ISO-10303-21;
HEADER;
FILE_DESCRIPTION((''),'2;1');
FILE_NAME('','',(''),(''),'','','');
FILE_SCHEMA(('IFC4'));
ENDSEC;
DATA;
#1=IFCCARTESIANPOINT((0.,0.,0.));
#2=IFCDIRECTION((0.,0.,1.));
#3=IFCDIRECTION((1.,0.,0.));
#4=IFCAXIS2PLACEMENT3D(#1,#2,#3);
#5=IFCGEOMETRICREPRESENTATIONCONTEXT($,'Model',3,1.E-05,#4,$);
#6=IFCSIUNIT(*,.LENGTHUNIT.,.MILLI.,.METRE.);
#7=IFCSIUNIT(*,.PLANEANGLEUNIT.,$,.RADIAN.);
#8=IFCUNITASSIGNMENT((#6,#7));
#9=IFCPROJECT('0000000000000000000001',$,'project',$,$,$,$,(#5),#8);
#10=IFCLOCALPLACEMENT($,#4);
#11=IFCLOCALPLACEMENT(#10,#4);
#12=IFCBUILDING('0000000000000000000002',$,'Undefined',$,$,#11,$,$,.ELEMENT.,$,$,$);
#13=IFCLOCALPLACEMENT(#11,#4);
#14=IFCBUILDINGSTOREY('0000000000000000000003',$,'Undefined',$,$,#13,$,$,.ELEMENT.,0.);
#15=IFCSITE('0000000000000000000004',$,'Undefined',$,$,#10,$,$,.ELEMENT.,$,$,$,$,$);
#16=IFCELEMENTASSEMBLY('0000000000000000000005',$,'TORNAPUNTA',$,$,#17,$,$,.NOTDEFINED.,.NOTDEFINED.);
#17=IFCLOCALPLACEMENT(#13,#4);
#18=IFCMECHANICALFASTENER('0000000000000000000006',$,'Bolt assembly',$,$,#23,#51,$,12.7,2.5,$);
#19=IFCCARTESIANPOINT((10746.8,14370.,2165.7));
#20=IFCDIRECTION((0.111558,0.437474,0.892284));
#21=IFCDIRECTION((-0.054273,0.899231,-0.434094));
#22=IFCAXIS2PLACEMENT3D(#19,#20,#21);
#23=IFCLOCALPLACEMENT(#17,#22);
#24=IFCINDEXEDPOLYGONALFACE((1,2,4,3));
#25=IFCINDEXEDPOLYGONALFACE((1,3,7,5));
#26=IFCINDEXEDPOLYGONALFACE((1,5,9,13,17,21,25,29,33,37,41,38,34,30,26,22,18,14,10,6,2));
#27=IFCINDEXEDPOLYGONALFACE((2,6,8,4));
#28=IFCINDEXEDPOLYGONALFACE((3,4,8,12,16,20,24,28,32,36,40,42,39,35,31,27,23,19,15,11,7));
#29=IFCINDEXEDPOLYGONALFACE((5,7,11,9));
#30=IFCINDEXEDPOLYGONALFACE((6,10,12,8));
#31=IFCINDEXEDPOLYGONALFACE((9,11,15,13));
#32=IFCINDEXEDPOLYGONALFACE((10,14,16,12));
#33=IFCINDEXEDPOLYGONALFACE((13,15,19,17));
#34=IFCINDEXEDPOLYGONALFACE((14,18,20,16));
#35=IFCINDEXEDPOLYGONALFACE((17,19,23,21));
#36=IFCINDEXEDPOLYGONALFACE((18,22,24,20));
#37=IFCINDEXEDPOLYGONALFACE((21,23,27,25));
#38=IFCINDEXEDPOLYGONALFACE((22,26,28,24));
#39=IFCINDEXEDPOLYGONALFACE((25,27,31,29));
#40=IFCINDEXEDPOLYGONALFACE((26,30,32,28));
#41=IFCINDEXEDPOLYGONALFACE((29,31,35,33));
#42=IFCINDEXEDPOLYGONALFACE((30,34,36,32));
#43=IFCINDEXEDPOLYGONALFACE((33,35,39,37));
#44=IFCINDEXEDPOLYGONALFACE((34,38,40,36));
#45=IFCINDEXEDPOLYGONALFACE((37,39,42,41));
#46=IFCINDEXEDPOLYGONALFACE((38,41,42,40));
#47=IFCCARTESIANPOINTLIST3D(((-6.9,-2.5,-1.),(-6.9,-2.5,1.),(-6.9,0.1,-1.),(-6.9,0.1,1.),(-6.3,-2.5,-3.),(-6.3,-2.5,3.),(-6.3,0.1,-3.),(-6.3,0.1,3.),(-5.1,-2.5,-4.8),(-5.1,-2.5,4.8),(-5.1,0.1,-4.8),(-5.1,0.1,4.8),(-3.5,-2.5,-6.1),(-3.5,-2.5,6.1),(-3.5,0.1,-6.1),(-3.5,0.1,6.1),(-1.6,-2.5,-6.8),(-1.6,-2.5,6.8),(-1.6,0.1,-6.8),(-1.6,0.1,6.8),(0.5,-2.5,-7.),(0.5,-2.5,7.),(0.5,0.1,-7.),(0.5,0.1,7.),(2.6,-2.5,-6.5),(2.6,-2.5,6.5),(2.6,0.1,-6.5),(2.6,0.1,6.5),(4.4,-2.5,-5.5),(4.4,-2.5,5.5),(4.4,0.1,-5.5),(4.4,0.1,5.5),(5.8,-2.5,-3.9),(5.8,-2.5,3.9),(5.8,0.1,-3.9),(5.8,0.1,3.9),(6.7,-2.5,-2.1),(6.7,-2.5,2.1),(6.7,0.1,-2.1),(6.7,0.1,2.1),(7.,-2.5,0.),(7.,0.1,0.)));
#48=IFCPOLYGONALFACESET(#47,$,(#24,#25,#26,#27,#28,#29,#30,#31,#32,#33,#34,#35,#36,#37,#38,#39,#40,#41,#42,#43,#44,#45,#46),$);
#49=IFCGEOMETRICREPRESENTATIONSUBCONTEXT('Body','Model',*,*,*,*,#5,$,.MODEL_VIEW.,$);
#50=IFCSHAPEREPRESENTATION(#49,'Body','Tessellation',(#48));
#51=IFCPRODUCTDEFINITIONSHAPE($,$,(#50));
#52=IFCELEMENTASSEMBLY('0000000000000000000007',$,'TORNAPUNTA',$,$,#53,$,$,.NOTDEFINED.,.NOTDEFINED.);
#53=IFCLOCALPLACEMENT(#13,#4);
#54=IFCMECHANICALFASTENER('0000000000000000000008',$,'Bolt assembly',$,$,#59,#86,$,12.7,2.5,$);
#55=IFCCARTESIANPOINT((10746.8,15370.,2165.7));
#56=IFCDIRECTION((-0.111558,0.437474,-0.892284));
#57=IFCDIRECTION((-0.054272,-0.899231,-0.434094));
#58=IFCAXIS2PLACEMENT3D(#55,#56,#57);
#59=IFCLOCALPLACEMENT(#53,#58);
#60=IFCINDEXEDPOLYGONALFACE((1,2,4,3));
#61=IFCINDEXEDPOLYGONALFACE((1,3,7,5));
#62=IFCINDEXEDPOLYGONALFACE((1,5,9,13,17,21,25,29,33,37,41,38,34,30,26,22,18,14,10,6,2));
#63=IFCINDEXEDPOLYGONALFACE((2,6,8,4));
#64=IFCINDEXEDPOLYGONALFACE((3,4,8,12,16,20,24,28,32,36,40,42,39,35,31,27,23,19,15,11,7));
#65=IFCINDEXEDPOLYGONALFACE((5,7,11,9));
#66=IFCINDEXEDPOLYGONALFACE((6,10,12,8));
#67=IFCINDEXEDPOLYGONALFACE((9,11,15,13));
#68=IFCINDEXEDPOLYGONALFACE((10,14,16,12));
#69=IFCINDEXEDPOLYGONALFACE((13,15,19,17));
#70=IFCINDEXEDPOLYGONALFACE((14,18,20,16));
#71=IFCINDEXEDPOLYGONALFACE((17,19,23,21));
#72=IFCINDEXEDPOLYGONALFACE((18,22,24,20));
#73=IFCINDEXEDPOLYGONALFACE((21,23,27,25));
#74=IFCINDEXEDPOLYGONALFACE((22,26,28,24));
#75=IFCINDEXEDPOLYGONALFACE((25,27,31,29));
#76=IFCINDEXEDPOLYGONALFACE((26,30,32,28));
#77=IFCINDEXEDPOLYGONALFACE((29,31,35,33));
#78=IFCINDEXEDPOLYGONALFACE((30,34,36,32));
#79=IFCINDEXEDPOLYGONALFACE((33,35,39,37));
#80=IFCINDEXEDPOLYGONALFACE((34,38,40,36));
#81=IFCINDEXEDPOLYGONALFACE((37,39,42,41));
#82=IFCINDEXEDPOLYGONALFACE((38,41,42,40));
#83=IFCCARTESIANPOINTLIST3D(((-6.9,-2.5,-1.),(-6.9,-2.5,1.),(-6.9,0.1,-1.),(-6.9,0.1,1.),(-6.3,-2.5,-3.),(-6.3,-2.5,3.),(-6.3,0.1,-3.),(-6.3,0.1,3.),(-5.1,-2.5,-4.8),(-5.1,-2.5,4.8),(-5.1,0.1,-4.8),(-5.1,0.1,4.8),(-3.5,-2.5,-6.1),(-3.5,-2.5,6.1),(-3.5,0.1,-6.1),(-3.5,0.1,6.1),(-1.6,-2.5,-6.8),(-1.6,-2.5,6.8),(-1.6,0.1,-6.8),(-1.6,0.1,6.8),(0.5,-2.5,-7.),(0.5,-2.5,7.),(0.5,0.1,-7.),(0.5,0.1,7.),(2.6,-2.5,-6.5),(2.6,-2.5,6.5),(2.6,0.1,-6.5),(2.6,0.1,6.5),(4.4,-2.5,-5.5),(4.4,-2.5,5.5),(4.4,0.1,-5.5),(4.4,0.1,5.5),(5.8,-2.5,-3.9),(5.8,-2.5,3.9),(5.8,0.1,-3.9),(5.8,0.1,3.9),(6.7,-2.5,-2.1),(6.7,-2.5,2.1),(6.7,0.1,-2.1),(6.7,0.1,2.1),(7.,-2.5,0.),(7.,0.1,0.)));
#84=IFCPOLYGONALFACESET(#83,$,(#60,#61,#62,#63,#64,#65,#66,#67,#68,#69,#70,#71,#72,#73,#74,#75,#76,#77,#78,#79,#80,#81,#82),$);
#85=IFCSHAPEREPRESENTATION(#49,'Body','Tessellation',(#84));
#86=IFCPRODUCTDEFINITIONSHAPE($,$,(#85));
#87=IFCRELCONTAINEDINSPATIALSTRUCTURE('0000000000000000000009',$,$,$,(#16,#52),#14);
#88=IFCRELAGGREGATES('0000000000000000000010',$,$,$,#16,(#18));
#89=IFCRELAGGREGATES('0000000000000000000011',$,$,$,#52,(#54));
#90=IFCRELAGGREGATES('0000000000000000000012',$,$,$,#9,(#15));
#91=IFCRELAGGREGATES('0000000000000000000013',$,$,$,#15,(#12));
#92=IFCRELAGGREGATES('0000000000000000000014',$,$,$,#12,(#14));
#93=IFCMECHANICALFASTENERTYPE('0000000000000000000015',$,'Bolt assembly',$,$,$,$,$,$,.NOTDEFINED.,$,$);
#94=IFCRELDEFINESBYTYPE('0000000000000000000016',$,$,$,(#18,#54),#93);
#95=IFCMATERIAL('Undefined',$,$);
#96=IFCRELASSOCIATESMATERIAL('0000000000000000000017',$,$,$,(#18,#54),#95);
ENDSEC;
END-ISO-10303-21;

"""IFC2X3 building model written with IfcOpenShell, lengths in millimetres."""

from ifc_helpers import new_model, si_unit, frame, origin_with_axes, origin_2d_with_axis, place, context, subcontext, project, spatial, circle, extrude, source, transform, mapped, material, type_object, element, aggregate, save


model = new_model("IFC2X3")

# Units and contexts
model_context = context("Model", 3, precision=1e-05, world=origin_with_axes())
body_context = subcontext(model_context, "Body", "Model", "MODEL_VIEW")
ifc_project = project(units=[si_unit("LENGTHUNIT", "METRE", prefix="MILLI"), si_unit("PLANEANGLEUNIT", "RADIAN")], contexts=[model_context])

# Site, building, storey
site_placement = place(None, origin_with_axes())
site = spatial("IfcSite", under=ifc_project, at=site_placement, Name="Undefined", CompositionType="ELEMENT")
building_placement = place(site_placement, origin_with_axes())
building = spatial("IfcBuilding", under=site, at=building_placement, Name="Undefined", CompositionType="ELEMENT")
storey_placement = place(building_placement, origin_with_axes())
storey = spatial("IfcBuildingStorey", under=building, at=storey_placement, Name="Undefined", CompositionType="ELEMENT", Elevation=0.0)

# Shared definitions
ifc_material_1 = material(Name="Undefined")
mechanical_fastener_type = type_object("IfcMechanicalFastenerType", Name="Bolt assembly")

# Element assemblies, mechanical fasteners
assembly_1_placement = place(storey_placement, origin_with_axes())
assembly_1 = element("IfcElementAssembly", 1, at=assembly_1_placement, inside=storey, Name="TORNAPUNTA", AssemblyPlace="NOTDEFINED", PredefinedType="NOTDEFINED")
shared_shape_1 = source(origin_with_axes(), body_context, "Body", "SweptSolid", [
    extrude(circle(Radius=7.0, at=origin_2d_with_axis()), frame((0.0, -2.5, 0.0), z_axis=(0.0, 1.0, 0.0), x_axis=(1.0, 0.0, 0.0)), (0.0, 0.0, 1.0), 2.6),
])
mechanical_fastener_1_placement = place(assembly_1_placement, frame((10746.8, 14370.0, 2165.7), z_axis=(0.111558, 0.437474, 0.892284), x_axis=(-0.054273, 0.899231, -0.434094)))
mechanical_fastener_1 = element("IfcMechanicalFastener", 2, at=mechanical_fastener_1_placement, type_object=mechanical_fastener_type, material=ifc_material_1, Name="Bolt assembly", NominalDiameter=12.7, NominalLength=2.5, context=body_context, shape_type="MappedRepresentation", body=[
    mapped(shared_shape_1, transform((0.0, 0.0, 0.0))),
])
aggregate(assembly_1, [mechanical_fastener_1])
assembly_2_placement = place(storey_placement, origin_with_axes())
assembly_2 = element("IfcElementAssembly", 3, at=assembly_2_placement, inside=storey, Name="TORNAPUNTA", AssemblyPlace="NOTDEFINED", PredefinedType="NOTDEFINED")
mechanical_fastener_2_placement = place(assembly_2_placement, frame((10746.8, 15370.0, 2165.7), z_axis=(-0.111558, 0.437474, -0.892284), x_axis=(-0.054272, -0.899231, -0.434094)))
mechanical_fastener_2 = element("IfcMechanicalFastener", 4, at=mechanical_fastener_2_placement, type_object=mechanical_fastener_type, material=ifc_material_1, Name="Bolt assembly", NominalDiameter=12.7, NominalLength=2.5, context=body_context, shape_type="MappedRepresentation", body=[
    mapped(shared_shape_1, transform((0.0, 0.0, 0.0))),
])
aggregate(assembly_2, [mechanical_fastener_2])

save(model, "model.ifc")
